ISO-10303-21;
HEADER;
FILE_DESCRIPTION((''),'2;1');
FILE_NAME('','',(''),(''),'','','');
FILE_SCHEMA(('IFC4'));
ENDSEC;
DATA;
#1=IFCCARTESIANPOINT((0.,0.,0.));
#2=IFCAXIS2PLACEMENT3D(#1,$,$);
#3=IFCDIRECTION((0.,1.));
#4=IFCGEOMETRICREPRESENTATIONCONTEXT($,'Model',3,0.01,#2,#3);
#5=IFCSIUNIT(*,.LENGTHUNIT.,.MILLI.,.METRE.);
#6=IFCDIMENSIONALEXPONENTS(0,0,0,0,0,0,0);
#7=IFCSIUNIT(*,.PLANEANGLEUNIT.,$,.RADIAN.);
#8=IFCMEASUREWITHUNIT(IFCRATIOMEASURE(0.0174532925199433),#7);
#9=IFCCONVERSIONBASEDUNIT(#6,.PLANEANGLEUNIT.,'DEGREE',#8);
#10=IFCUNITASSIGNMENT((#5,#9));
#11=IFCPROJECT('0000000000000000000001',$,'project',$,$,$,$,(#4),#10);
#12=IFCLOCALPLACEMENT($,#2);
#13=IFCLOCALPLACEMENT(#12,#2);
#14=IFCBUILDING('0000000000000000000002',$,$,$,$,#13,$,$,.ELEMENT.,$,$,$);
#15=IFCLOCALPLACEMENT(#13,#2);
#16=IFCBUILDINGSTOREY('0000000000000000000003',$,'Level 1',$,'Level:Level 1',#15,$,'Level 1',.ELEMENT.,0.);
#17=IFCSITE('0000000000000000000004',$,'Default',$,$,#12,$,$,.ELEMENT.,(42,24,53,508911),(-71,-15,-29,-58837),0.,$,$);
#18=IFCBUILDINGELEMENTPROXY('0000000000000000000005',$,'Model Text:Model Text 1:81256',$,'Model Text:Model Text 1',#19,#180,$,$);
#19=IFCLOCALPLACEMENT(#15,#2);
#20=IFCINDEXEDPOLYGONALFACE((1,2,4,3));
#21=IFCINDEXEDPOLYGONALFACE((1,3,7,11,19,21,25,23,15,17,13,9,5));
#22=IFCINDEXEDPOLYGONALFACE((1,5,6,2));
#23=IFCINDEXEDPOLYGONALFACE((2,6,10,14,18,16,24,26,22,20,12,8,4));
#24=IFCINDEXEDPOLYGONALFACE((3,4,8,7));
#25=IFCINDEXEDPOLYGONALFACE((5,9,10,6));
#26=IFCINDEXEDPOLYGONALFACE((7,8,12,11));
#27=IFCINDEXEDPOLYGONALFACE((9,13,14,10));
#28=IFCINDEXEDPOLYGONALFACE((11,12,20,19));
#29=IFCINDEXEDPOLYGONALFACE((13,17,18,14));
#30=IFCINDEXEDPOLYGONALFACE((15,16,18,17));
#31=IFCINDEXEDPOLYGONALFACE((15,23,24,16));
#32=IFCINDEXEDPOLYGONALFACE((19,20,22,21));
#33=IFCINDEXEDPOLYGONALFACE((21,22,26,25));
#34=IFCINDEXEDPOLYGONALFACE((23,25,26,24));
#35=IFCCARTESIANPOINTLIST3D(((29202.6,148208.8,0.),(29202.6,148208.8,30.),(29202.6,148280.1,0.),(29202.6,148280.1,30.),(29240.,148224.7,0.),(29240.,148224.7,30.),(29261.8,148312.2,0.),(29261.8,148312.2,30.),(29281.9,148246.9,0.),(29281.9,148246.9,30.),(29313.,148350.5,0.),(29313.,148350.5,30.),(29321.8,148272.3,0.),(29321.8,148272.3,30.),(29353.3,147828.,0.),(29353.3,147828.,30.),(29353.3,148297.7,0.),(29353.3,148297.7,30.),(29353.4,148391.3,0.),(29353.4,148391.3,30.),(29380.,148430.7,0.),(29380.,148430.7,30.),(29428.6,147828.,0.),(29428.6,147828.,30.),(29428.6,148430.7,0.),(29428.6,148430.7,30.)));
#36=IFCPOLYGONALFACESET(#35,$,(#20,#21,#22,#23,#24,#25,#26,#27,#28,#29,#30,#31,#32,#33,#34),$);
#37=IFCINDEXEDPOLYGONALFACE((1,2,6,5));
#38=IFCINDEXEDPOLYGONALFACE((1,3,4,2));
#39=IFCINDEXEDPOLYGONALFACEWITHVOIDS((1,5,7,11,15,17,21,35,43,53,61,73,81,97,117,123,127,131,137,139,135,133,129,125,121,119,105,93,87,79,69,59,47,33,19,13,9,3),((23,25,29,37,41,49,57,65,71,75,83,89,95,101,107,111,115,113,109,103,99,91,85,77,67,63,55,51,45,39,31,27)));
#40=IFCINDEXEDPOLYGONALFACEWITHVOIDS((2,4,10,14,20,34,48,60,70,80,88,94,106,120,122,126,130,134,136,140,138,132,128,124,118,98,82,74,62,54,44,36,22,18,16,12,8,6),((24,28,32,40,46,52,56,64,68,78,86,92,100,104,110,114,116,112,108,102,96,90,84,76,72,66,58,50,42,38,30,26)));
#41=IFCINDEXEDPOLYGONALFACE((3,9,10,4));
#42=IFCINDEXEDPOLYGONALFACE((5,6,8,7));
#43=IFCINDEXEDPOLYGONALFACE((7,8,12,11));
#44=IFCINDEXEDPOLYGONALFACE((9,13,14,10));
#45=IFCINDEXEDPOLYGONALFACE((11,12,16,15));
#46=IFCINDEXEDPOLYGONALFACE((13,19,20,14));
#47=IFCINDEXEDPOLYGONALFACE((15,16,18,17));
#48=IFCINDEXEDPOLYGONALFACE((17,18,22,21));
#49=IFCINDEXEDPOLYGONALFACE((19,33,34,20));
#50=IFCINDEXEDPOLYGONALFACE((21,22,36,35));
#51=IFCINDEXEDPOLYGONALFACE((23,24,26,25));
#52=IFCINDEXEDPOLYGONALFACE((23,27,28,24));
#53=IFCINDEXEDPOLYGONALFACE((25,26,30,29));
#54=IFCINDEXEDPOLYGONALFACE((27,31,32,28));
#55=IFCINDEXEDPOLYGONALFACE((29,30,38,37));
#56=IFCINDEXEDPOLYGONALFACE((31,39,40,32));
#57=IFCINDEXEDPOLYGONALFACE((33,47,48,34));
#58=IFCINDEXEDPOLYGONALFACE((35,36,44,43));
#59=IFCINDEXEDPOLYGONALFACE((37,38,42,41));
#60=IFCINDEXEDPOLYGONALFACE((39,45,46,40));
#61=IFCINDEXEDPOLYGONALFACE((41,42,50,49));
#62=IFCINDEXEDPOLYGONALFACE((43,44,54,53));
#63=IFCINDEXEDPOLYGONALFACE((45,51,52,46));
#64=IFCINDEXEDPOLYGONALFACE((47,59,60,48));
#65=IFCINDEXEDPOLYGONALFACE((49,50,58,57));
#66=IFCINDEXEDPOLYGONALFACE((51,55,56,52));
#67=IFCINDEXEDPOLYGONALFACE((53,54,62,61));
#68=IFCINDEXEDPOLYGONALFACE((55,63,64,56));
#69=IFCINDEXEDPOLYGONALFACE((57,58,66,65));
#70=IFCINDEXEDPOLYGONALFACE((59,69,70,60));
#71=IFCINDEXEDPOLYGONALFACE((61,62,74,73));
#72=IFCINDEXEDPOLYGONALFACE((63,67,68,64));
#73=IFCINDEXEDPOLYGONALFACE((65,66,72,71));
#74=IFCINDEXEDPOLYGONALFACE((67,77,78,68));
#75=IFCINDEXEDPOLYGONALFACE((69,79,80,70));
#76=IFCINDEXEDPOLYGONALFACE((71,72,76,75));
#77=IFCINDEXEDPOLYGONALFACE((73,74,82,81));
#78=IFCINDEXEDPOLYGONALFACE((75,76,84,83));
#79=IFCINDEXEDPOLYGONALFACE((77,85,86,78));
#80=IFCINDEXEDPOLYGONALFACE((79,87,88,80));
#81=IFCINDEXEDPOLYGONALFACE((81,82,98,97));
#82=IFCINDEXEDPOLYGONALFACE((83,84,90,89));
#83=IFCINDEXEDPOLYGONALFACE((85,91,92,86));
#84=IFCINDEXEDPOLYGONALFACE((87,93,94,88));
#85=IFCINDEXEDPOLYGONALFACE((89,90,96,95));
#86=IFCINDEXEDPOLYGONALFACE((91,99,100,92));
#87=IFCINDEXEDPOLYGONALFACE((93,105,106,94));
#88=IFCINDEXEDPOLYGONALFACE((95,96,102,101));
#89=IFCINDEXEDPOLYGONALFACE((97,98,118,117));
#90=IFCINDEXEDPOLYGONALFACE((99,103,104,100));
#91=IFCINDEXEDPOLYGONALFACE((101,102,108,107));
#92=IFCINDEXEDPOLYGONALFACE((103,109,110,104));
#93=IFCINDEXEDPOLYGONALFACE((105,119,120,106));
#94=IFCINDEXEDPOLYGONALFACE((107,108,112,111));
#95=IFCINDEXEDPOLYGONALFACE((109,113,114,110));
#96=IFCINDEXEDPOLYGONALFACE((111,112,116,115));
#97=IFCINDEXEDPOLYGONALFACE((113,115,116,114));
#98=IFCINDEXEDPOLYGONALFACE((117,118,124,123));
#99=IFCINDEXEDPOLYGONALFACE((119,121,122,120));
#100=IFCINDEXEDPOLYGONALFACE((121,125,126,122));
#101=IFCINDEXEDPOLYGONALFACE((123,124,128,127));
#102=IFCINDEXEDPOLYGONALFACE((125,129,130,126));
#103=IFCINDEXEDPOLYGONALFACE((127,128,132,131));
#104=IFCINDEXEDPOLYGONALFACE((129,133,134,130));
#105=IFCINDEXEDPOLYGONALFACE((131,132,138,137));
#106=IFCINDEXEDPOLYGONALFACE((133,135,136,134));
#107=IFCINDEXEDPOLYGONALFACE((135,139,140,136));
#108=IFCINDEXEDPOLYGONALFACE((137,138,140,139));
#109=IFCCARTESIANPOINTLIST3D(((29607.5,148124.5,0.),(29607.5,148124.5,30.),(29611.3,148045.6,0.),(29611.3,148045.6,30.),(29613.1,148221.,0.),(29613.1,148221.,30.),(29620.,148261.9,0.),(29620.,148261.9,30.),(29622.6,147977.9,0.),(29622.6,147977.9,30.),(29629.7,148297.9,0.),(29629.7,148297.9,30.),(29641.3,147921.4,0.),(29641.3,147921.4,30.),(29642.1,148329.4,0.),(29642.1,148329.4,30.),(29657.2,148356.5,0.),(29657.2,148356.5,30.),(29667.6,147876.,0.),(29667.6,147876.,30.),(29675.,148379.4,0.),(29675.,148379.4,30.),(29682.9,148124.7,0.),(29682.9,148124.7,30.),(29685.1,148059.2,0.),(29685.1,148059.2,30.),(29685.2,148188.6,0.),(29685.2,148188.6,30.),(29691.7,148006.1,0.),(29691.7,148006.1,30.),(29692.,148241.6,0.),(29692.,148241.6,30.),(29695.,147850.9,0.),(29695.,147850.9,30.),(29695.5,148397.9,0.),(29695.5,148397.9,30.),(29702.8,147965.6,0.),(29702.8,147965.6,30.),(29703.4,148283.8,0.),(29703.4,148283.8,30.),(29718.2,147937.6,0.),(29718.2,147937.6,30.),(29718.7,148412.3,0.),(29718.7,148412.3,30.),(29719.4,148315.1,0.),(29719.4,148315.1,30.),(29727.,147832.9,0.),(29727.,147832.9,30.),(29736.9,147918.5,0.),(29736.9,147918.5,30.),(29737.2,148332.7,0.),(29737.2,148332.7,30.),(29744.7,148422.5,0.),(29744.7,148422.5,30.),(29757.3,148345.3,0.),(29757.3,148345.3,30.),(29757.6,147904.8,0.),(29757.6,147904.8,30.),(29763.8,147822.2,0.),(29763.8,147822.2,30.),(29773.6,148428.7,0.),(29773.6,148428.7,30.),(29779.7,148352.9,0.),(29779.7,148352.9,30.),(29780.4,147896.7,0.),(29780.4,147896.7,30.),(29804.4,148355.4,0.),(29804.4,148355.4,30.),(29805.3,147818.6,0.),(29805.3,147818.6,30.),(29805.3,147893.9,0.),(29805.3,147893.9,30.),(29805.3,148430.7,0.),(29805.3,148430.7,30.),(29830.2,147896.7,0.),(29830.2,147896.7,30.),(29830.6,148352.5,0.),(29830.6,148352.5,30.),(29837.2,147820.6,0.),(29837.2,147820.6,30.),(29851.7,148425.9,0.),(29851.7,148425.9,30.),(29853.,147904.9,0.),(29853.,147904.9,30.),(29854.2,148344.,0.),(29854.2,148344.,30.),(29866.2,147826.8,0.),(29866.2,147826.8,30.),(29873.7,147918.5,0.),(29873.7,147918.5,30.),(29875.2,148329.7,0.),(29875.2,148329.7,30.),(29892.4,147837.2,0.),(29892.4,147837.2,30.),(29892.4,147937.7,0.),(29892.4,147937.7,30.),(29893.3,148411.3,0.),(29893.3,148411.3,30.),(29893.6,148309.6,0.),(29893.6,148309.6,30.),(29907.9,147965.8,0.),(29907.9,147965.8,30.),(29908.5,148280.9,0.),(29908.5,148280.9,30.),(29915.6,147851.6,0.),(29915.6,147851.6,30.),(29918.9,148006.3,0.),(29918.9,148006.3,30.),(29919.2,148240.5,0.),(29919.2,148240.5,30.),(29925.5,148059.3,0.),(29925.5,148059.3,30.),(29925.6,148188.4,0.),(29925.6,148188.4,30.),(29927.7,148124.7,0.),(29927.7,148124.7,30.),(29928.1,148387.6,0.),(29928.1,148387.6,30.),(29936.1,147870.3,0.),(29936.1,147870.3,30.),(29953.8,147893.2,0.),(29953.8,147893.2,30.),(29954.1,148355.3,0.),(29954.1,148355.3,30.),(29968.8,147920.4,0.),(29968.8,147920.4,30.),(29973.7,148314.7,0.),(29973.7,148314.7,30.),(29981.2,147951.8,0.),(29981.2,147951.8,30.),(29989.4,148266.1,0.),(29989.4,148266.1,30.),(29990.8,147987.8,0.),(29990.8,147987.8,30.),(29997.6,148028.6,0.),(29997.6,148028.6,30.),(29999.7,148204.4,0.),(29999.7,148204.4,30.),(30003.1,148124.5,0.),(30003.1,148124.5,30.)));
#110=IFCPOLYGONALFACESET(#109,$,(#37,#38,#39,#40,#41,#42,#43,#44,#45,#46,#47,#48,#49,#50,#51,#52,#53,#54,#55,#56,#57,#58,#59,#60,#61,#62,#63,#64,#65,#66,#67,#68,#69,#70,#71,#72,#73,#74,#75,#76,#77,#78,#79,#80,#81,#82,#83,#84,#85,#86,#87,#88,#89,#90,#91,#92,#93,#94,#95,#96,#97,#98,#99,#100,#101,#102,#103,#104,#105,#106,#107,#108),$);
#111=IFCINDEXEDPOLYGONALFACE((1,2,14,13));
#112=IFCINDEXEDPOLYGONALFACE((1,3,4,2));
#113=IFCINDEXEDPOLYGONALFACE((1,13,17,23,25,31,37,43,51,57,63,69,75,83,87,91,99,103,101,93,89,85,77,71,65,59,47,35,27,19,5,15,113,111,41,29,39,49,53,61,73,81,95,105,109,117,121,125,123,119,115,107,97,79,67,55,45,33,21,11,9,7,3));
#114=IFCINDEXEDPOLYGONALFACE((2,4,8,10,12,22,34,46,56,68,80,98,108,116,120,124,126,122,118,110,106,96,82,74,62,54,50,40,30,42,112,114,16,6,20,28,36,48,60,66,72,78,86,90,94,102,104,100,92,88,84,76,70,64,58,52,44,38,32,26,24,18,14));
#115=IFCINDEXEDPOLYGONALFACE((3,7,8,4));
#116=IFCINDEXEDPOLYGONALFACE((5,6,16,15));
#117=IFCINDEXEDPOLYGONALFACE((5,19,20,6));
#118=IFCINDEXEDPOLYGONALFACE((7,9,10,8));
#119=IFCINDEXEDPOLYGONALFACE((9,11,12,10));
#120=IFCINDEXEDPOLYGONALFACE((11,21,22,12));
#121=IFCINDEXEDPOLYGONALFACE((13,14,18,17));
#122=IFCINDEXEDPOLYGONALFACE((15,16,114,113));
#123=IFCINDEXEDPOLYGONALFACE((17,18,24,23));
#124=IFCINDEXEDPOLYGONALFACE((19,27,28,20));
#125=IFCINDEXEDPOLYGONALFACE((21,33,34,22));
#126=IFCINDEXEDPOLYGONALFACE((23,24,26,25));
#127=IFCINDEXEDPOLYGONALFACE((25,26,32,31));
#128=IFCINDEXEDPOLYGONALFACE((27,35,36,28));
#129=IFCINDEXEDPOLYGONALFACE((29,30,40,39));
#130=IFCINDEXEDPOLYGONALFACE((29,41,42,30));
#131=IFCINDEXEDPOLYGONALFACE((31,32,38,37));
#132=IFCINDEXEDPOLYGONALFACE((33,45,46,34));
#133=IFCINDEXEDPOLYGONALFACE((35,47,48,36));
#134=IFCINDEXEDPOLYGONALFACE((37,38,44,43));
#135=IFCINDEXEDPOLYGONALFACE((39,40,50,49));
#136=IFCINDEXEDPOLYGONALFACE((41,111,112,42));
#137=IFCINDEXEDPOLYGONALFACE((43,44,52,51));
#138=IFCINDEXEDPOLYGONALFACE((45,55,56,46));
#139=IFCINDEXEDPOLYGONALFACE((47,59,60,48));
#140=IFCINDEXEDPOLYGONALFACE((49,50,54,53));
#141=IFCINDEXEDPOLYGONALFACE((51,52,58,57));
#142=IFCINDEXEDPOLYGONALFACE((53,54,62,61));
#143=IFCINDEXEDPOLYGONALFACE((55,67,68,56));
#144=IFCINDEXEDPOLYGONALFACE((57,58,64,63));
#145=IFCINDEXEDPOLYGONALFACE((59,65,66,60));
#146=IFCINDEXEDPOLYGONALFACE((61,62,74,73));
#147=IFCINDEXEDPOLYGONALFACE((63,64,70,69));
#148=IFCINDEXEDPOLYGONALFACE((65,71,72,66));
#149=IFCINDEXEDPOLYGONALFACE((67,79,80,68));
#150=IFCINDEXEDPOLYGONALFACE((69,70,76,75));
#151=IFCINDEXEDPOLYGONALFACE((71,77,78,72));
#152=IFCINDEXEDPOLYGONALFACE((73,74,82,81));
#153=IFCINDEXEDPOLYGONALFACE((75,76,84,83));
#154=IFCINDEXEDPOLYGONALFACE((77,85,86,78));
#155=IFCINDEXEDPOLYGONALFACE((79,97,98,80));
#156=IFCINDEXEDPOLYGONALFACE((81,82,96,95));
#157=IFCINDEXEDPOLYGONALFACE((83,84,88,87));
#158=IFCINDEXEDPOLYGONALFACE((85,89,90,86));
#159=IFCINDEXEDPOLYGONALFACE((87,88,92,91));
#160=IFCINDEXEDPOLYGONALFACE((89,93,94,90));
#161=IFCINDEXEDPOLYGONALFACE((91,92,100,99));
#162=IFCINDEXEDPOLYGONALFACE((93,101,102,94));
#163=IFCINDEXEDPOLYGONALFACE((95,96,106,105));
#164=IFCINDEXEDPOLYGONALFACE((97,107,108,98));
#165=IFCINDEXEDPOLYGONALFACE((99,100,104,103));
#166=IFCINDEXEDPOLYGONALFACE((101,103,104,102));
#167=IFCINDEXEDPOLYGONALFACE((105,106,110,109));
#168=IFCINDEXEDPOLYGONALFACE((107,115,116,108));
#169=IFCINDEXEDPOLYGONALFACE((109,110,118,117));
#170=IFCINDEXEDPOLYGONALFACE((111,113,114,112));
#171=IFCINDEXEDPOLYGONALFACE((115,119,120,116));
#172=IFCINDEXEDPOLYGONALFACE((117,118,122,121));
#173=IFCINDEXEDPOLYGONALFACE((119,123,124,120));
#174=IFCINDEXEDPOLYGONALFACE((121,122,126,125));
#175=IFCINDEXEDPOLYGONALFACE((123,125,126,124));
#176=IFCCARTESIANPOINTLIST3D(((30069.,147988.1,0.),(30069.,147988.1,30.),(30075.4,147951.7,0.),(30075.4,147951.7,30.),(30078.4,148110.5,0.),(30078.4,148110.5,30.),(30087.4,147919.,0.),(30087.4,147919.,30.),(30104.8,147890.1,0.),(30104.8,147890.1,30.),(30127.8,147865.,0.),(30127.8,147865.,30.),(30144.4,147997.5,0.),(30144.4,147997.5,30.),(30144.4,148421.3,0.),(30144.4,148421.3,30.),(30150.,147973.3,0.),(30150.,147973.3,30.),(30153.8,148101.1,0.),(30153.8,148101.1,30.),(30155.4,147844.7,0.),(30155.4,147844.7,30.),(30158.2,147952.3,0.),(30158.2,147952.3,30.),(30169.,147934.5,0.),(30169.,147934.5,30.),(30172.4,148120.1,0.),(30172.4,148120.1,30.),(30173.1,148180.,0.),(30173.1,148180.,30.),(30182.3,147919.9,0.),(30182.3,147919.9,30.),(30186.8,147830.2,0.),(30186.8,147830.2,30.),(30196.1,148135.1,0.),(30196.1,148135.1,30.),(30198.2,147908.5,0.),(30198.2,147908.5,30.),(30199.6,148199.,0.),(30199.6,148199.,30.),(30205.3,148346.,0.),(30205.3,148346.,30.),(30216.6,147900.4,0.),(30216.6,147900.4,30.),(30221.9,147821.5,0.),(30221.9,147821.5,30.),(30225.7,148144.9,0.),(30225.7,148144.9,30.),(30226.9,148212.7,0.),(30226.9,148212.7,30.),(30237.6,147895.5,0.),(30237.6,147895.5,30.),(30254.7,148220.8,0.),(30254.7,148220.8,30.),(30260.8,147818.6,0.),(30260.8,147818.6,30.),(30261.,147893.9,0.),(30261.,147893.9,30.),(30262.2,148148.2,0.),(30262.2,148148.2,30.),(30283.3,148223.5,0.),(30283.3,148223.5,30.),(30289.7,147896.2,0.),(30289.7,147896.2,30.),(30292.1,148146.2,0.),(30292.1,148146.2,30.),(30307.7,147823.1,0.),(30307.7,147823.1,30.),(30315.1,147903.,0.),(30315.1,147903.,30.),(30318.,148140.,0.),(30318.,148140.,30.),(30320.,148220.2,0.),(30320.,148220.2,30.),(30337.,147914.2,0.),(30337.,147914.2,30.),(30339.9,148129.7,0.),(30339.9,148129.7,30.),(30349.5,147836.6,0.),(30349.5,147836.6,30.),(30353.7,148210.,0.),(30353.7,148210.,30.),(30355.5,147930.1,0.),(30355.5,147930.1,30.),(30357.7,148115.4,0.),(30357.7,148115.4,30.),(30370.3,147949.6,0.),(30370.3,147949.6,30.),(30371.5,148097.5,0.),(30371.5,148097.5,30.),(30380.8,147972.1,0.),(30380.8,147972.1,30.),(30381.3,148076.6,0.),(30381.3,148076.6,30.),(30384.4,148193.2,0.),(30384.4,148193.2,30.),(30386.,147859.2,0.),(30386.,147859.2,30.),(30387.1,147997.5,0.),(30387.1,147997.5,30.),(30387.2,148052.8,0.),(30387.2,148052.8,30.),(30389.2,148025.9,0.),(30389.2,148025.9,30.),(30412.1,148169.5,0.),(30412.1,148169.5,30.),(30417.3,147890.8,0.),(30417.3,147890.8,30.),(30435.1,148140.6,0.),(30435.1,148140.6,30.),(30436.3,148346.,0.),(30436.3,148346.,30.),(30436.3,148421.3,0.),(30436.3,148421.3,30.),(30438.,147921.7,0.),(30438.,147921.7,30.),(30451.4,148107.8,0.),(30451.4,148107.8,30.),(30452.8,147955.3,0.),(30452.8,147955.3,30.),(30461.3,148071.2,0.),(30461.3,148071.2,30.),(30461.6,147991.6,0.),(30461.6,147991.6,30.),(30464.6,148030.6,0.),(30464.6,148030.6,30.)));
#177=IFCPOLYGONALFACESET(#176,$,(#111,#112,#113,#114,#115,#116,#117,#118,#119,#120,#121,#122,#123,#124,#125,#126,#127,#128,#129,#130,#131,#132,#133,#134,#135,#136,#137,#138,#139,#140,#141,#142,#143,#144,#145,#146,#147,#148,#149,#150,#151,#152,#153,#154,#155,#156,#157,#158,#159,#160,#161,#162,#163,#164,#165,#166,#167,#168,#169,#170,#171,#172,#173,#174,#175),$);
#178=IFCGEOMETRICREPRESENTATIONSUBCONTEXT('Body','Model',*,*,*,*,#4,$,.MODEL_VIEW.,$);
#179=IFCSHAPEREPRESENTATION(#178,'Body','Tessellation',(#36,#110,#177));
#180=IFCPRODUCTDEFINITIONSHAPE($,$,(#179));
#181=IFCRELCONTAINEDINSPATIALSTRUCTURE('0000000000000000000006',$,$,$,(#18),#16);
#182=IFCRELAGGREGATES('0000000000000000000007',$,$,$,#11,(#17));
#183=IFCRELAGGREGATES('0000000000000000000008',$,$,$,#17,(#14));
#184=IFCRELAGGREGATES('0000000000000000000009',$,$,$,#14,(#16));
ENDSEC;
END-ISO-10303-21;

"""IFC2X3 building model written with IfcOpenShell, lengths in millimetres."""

from ifc_helpers import new_model, entity, si_unit, converted_unit, direction, frame, origin, place, context, subcontext, project, spatial, polyline, outline, extrude, element, save


model = new_model("IFC2X3")

# Units and contexts
model_context = context("Model", 3, precision=0.01, world=origin(), true_north=direction((0.0, 1.0)))
body_context = subcontext(model_context, "Body", "Model", "MODEL_VIEW")
ifc_project = project(units=[si_unit("LENGTHUNIT", "METRE", prefix="MILLI"), converted_unit("PLANEANGLEUNIT", "DEGREE", entity("IfcRatioMeasure", 0.0174532925199433), si_unit("PLANEANGLEUNIT", "RADIAN"), dimensions=[0, 0, 0, 0, 0, 0, 0])], contexts=[model_context])

# Site, building, storey
site_placement = place(None, origin())
site = spatial("IfcSite", under=ifc_project, at=site_placement, Name="Default", CompositionType="ELEMENT", RefLatitude=(42, 24, 53, 508911), RefLongitude=(-71, -15, -29, -58837), RefElevation=0.0)
building_placement = place(site_placement, origin())
building = spatial("IfcBuilding", under=site, at=building_placement, CompositionType="ELEMENT")
storey_placement = place(building_placement, origin())
storey = spatial("IfcBuildingStorey", under=building, at=storey_placement, Name="Level 1", ObjectType="Level:Level 1", LongName="Level 1", CompositionType="ELEMENT", Elevation=0.0)

# Building element proxy
proxy_1_placement = place(storey_placement, origin())
element("IfcBuildingElementProxy", 1, at=proxy_1_placement, inside=storey, Name="Model Text:Model Text 1:81256", ObjectType="Model Text:Model Text 1", context=body_context, shape_type="SweptSolid", body=[
    extrude(outline(polyline([(-410.6, -111.6), (192.1, -111.6), (192.1, -63.1), (152.7, -36.4), (111.9, 4.0), (73.6, 55.2), (41.4, 114.4), (-29.8, 114.4), (-13.9, 77.0), (8.3, 35.1), (33.7, -4.8), (59.1, -36.3), (-410.6, -36.3), (-410.6, -111.6)])), frame((29317.0, 148238.6, 0.0), z_axis=(0.0, 0.0, 1.0), x_axis=(0.0, 1.0, 0.0)), (0.0, 0.0, 1.0), 30.0),
    extrude(outline(polyline([(-10.6, -198.7), (68.3, -198.7), (136.5, -190.7), (193.9, -174.7), (240.5, -150.6), (266.9, -124.4), (286.3, -93.2), (298.8, -57.0), (304.3, -15.7), (303.8, 16.2), (299.0, 45.5), (289.9, 72.1), (276.6, 96.0), (258.9, 117.3), (236.9, 136.2), (210.4, 152.5), (179.6, 166.3), (144.1, 177.6), (103.7, 186.3), (8.2, 196.4), (-71.8, 196.7), (-134.0, 189.4), (-183.3, 176.1), (-224.7, 158.4), (-258.2, 133.9), (-283.5, 100.3), (-300.1, 59.5), (-307.1, 13.4), (-306.6, -18.4), (-301.8, -47.5), (-292.8, -74.0), (-279.6, -97.9), (-262.0, -119.2), (-240.0, -138.1), (-213.6, -154.5), (-182.8, -168.4), (-147.3, -179.8), (-106.7, -188.6), (-10.6, -198.7)]), holes=[polyline([(-7.2, -123.5), (-71.0, -118.2), (-123.6, -108.8), (-165.2, -95.4), (-195.7, -78.0), (-212.4, -59.4), (-224.1, -38.7), (-230.6, -15.9), (-231.9, 8.9), (-227.8, 35.0), (-218.1, 58.1), (-202.8, 78.4), (-182.0, 95.8), (-152.6, 109.4), (-111.7, 118.1), (-59.4, 122.0), (4.4, 121.1), (69.6, 115.8), (122.2, 106.7), (162.2, 93.7), (189.5, 77.0), (207.7, 57.4), (220.4, 36.0), (227.5, 12.8), (229.1, -12.1), (225.2, -36.8), (215.9, -59.2), (201.3, -79.3), (181.4, -97.1), (152.6, -111.2), (111.6, -120.3), (58.3, -124.4), (-7.2, -123.5)])]), frame((29806.6, 148123.3, 0.0), z_axis=(0.0, 0.0, 1.0), x_axis=(0.047515, -0.998871, 0.0)), (0.0, 0.0, 1.0), 30.0),
    extrude(outline(polyline([(12.1, -219.3), (49.1, -219.3), (83.4, -213.2), (114.8, -201.1), (143.5, -182.8), (168.3, -159.2), (188.1, -130.8), (202.8, -97.8), (212.4, -60.0), (216.1, -12.9), (210.0, 30.5), (194.1, 70.4), (168.4, 106.8), (141.6, 132.5), (111.1, 152.9), (76.9, 167.9), (39.0, 177.6), (-1.5, 181.4), (-39.3, 178.1), (-74.4, 167.6), (-106.9, 150.1), (-135.0, 126.9), (-157.0, 99.6), (-172.8, 68.1), (-182.5, 32.6), (-184.8, 4.0), (-181.6, -24.8), (-172.9, -54.0), (-158.8, -83.5), (-316.6, -22.9), (-276.5, 204.6), (-350.7, 217.7), (-401.4, -69.8), (-106.8, -188.8), (-84.5, -116.2), (-99.9, -94.5), (-110.6, -68.6), (-115.1, -37.8), (-112.0, -1.2), (-104.8, 27.9), (-94.2, 52.3), (-80.3, 72.0), (-63.1, 87.0), (-43.0, 97.5), (-20.8, 103.6), (3.8, 105.3), (30.5, 102.6), (58.1, 95.6), (82.1, 84.9), (102.4, 70.6), (119.1, 52.7), (131.4, 31.7), (138.7, 8.2), (141.0, -17.9), (138.2, -46.6), (132.6, -69.4), (124.1, -89.2), (112.9, -105.9), (99.0, -119.6), (82.3, -130.2), (62.9, -137.7), (40.8, -142.2), (15.9, -143.5), (12.1, -219.3)])), frame((30282.9, 148038.2, 0.0), z_axis=(0.0, 0.0, 1.0), x_axis=(0.173842, -0.984774, 0.0)), (0.0, 0.0, 1.0), 30.0),
])

save(model, "model.ifc")
